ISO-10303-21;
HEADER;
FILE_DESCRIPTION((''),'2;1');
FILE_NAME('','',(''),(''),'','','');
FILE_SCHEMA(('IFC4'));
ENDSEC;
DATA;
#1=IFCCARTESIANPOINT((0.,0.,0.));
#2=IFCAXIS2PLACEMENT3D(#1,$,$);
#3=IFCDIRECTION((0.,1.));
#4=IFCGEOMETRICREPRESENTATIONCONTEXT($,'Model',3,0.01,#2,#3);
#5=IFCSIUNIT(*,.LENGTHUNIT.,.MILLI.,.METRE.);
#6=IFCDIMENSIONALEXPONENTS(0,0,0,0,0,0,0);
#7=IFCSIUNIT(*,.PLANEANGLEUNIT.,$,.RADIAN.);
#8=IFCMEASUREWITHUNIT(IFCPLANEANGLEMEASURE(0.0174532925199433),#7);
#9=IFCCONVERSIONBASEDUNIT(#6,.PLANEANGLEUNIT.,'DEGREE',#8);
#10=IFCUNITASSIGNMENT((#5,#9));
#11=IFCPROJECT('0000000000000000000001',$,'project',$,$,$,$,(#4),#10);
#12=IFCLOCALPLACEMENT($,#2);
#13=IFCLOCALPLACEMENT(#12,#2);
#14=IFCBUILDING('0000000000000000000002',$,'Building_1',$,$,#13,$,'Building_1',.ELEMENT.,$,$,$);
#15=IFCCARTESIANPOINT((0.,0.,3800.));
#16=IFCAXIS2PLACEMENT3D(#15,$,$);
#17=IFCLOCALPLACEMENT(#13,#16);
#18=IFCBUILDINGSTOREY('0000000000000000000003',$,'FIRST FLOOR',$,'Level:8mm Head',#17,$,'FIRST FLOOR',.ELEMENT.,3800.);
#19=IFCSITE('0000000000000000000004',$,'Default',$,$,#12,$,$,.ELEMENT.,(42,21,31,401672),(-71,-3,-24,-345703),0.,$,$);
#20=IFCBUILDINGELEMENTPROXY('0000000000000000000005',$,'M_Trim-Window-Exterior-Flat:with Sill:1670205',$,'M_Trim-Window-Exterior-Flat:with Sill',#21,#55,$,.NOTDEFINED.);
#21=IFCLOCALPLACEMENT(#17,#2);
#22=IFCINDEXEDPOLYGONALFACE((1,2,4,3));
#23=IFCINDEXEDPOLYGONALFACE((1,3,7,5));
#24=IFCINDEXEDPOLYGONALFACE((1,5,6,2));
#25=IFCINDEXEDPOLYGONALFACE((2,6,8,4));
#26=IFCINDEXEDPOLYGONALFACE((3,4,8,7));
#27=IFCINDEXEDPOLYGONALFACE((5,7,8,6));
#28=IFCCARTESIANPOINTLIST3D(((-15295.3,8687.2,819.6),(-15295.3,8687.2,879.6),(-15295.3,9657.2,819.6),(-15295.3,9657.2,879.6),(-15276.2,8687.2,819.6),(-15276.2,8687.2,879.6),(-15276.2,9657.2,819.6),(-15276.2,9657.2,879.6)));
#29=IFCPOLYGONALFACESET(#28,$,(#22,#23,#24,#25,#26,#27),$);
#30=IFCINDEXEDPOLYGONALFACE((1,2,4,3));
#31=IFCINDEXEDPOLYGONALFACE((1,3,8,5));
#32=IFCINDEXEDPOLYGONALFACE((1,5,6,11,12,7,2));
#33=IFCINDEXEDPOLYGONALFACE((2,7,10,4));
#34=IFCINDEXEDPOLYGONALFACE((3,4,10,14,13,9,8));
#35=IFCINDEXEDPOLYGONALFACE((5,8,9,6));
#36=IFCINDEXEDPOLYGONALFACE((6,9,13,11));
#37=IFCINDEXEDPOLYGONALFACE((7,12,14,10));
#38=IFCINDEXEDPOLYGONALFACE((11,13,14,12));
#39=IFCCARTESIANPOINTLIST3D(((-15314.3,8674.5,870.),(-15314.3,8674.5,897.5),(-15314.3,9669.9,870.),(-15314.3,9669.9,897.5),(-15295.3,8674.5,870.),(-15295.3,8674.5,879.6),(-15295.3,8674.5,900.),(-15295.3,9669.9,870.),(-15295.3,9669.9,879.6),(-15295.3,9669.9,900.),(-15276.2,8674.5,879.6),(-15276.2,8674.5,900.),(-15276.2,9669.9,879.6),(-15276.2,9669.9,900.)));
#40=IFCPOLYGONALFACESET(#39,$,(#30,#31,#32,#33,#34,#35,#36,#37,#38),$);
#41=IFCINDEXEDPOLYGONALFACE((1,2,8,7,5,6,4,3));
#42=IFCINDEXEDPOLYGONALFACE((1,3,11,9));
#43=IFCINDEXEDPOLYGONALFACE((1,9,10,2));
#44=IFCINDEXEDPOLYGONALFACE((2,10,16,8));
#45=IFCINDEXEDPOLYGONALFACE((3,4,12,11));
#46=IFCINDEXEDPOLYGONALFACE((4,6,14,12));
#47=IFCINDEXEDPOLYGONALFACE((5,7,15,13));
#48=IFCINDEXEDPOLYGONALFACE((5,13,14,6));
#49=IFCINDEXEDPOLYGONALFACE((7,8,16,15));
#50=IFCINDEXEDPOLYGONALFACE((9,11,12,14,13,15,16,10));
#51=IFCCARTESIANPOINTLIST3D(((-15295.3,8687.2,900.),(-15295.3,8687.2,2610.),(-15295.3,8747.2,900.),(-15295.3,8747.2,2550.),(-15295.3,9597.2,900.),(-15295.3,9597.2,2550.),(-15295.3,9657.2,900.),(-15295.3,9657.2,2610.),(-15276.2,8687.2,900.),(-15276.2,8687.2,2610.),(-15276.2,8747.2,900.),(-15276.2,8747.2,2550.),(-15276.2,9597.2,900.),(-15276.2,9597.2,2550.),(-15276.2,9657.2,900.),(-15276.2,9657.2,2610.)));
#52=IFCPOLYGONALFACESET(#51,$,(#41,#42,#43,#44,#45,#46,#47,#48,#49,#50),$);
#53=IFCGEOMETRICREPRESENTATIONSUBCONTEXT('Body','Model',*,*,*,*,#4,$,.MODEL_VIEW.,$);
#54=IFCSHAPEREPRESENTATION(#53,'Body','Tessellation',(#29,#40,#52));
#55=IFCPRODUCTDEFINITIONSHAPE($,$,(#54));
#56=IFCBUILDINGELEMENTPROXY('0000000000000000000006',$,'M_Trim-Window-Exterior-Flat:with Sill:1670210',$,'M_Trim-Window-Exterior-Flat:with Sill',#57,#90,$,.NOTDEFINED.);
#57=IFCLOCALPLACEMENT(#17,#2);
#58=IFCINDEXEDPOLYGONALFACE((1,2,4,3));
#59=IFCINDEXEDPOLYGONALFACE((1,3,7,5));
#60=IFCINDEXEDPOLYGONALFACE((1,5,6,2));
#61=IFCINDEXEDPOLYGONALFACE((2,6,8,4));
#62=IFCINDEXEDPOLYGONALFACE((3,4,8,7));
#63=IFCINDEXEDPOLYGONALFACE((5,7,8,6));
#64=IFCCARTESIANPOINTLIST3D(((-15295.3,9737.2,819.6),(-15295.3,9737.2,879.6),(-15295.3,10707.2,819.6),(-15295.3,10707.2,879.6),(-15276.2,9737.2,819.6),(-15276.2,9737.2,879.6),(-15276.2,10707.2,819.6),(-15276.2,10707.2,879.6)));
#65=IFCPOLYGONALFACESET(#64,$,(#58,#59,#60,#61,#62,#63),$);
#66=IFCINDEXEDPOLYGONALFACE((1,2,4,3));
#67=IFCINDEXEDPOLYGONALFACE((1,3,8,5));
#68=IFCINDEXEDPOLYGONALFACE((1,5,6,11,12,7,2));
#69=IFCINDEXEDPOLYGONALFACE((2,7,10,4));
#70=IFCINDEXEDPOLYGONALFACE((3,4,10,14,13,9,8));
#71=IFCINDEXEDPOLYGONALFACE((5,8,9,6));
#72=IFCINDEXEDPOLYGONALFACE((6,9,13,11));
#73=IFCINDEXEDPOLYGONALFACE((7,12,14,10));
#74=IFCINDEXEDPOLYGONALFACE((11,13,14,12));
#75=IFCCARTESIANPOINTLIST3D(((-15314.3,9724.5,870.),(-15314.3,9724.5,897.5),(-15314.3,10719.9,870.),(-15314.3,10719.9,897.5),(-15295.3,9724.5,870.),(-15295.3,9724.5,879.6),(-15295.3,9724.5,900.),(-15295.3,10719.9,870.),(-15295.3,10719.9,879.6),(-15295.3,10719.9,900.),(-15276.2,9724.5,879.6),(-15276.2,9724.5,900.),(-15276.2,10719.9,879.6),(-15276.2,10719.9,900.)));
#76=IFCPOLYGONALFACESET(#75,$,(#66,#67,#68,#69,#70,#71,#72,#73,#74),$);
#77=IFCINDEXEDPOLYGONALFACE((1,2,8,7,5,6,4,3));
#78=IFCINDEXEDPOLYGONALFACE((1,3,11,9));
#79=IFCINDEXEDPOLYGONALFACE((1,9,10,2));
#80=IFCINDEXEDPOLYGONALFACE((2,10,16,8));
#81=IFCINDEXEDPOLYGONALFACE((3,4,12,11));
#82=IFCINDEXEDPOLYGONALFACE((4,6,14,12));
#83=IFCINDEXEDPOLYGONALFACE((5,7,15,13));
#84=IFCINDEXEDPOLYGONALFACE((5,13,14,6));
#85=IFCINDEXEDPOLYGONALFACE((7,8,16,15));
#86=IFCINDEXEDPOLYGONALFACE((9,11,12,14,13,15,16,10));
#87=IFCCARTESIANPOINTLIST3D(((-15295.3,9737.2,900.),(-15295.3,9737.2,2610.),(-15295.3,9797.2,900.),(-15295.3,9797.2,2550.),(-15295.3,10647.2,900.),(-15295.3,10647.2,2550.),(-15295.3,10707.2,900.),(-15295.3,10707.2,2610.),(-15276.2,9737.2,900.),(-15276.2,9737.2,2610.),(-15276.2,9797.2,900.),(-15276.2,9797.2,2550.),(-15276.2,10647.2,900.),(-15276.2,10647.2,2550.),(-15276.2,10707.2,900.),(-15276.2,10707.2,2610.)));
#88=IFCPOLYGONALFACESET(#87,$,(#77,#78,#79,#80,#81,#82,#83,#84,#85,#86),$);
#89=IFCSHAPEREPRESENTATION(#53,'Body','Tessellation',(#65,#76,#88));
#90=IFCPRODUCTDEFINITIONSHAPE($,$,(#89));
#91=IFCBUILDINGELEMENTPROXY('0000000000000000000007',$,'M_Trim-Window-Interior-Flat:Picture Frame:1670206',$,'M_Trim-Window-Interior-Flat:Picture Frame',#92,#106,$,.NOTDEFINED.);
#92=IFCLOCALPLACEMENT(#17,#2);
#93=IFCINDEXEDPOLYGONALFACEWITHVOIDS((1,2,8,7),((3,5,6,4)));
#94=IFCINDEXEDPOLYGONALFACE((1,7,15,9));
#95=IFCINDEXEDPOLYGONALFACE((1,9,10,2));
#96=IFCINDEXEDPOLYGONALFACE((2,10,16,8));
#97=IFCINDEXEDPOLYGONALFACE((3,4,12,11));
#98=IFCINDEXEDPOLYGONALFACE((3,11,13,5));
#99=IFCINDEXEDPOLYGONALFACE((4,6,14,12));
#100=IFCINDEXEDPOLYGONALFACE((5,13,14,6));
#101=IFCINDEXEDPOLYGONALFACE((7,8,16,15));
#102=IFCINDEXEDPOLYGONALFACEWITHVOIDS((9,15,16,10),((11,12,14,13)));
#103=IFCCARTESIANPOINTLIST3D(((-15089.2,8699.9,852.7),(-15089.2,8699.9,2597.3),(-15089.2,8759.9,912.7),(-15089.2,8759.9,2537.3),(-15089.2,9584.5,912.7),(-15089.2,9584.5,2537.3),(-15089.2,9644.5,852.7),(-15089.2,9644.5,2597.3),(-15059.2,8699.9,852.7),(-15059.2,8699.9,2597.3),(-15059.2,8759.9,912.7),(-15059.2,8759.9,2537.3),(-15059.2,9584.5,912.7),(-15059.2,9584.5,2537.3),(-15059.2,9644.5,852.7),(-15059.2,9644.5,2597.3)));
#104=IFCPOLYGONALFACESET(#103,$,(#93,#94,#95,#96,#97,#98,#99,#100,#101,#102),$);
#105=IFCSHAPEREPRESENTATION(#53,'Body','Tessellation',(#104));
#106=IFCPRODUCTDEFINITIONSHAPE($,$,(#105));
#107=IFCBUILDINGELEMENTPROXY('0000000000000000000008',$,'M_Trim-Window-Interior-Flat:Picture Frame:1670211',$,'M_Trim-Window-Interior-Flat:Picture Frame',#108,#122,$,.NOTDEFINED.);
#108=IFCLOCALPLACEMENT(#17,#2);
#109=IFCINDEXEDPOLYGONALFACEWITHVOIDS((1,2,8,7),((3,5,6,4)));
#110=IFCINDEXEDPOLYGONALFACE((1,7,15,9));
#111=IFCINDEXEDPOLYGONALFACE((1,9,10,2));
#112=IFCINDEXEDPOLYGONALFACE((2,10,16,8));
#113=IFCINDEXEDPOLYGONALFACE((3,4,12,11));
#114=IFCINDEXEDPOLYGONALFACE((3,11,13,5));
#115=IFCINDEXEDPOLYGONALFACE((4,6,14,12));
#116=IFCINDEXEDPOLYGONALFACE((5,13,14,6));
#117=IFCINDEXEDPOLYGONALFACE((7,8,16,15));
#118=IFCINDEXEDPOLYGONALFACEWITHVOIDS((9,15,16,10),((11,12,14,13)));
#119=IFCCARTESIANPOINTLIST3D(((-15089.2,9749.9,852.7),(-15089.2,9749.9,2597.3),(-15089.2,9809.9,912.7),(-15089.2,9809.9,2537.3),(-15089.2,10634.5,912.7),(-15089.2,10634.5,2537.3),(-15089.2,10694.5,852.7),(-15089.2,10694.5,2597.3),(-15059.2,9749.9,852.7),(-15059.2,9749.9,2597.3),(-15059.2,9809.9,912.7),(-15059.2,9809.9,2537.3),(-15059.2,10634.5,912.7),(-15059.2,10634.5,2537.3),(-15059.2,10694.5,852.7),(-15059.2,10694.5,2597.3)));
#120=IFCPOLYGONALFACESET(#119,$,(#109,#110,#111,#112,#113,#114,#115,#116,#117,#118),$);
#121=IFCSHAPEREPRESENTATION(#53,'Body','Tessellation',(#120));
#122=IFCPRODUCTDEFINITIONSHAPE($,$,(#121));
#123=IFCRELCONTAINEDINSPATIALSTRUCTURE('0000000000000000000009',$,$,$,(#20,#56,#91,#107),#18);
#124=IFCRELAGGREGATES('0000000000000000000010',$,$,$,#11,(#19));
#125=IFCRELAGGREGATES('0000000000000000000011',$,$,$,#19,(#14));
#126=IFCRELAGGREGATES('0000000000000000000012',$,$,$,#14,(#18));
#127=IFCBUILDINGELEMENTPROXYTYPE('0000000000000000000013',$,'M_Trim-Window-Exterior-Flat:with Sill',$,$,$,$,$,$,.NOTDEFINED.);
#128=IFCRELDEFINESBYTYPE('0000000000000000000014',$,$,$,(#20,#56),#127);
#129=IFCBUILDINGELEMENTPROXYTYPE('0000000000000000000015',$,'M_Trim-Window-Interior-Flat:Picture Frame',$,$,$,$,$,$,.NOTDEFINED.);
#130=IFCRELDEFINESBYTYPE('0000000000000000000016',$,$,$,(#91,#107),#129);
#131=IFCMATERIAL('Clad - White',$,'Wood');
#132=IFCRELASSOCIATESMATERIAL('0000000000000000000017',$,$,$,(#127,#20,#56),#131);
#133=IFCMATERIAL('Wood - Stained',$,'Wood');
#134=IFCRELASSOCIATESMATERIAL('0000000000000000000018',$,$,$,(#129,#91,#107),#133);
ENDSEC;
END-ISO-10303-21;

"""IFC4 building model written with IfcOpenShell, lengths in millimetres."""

from ifc_helpers import new_model, entity, si_unit, converted_unit, direction, frame, origin, place, context, subcontext, project, spatial, indexed_curve, outline, extrude, source, transform, mapped, material, type_object, type_shapes, element, save


model = new_model("IFC4")

# Units and contexts
model_context = context("Model", 3, precision=0.01, world=origin(), true_north=direction((0.0, 1.0)))
body_context = subcontext(model_context, "Body", "Model", "MODEL_VIEW")
ifc_project = project(units=[si_unit("LENGTHUNIT", "METRE", prefix="MILLI"), converted_unit("PLANEANGLEUNIT", "DEGREE", entity("IfcPlaneAngleMeasure", 0.0174532925199433), si_unit("PLANEANGLEUNIT", "RADIAN"), dimensions=[0, 0, 0, 0, 0, 0, 0])], contexts=[model_context])

# Site, building, storey
site_placement = place(None, origin())
site = spatial("IfcSite", under=ifc_project, at=site_placement, Name="Default", CompositionType="ELEMENT", RefLatitude=(42, 21, 31, 401672), RefLongitude=(-71, -3, -24, -345703), RefElevation=0.0)
building_placement = place(site_placement, origin())
building = spatial("IfcBuilding", under=site, at=building_placement, Name="Building_1", LongName="Building_1", CompositionType="ELEMENT")
storey_placement = place(building_placement, frame((0.0, 0.0, 3800.0)))
storey = spatial("IfcBuildingStorey", under=building, at=storey_placement, Name="FIRST FLOOR", ObjectType="Level:8mm Head", LongName="FIRST FLOOR", CompositionType="ELEMENT", Elevation=3800.0)

# Shared definitions
ifc_material_1 = material(Name="Wood - Stained", Category="Wood")

# Building element proxies
ifc_material_2 = material(Name="Clad - White", Category="Wood")
building_element_proxy_type_1 = type_object("IfcBuildingElementProxyType", Name="M_Trim-Window-Exterior-Flat:with Sill", PredefinedType="NOTDEFINED", material=ifc_material_2)
shared_shape_1 = source(origin(), body_context, "Body", "SweptSolid", [
    extrude(outline(indexed_curve([(-485.0, -30.0), (485.0, -30.0), (485.0, 30.0), (-485.0, 30.0), (-485.0, -30.0)], self_intersect=False)), frame((0.0, -1700.4, 0.0), z_axis=(0.0, 0.0, 1.0), x_axis=(-1.0, 0.0, 0.0)), (0.0, 0.0, 1.0), 19.1),
    extrude(outline(indexed_curve([(-19.0, -15.2), (0.0, -15.2), (0.0, -5.7), (19.0, -5.7), (19.0, 14.8), (0.0, 14.8), (-19.0, 12.3), (-19.0, -15.2)], self_intersect=False)), frame((-497.7, -1664.8, 19.0), z_axis=(1.0, 0.0, 0.0), x_axis=(0.0, 0.0, -1.0)), (0.0, 0.0, 1.0), 995.4),
    extrude(outline(indexed_curve([(-870.0, -485.0), (840.0, -485.0), (840.0, -425.0), (-810.0, -425.0), (-810.0, 425.0), (840.0, 425.0), (840.0, 485.0), (-870.0, 485.0), (-870.0, -485.0)], self_intersect=False)), frame((0.0, -810.0, 0.0), z_axis=(0.0, 0.0, 1.0), x_axis=(0.0, -1.0, 0.0)), (0.0, 0.0, 1.0), 19.1),
])
type_shapes(building_element_proxy_type_1, [shared_shape_1])
for number, where, z_axis, x_axis, name in (
    (1, (-15276.2, 9172.2, 2550.0), (-1.0, 0.0, 0.0), (0.0, -1.0, 0.0), "M_Trim-Window-Exterior-Flat:with Sill:1670205"),
    (2, (-15276.2, 10222.2, 2550.0), (-1.0, 0.0, 0.0), (0.0, -1.0, 0.0), "M_Trim-Window-Exterior-Flat:with Sill:1670210"),
):
    element("IfcBuildingElementProxy", number, at=place(storey_placement, frame(where, z_axis=z_axis, x_axis=x_axis)), inside=storey, type_object=building_element_proxy_type_1, material=ifc_material_2, Name=name, ObjectType="M_Trim-Window-Exterior-Flat:with Sill", PredefinedType="NOTDEFINED", context=body_context, shape_type="MappedRepresentation", body=[
        mapped(shared_shape_1, transform((0.0, 0.0, 0.0), scale=1.0)),
    ])
building_element_proxy_type_2 = type_object("IfcBuildingElementProxyType", Name="M_Trim-Window-Interior-Flat:Picture Frame", PredefinedType="NOTDEFINED", material=ifc_material_1)
shared_shape_2 = source(origin(), body_context, "Body", "SweptSolid", [
    extrude(outline(indexed_curve([(-472.3, -872.3), (472.3, -872.3), (472.3, 872.3), (-472.3, 872.3), (-472.3, -872.3)], self_intersect=False), holes=[indexed_curve([(-412.3, -812.3), (-412.3, 812.3), (412.3, 812.3), (412.3, -812.3), (-412.3, -812.3)], self_intersect=False)]), frame((0.0, -825.0, 0.0), z_axis=(0.0, 0.0, 1.0), x_axis=(-1.0, 0.0, 0.0)), (0.0, 0.0, 1.0), 30.0),
])
type_shapes(building_element_proxy_type_2, [shared_shape_2])
for number, where, z_axis, x_axis, name in (
    (3, (-15089.2, 9172.2, 2550.0), (1.0, 0.0, 0.0), (0.0, 1.0, 0.0), "M_Trim-Window-Interior-Flat:Picture Frame:1670206"),
    (4, (-15089.2, 10222.2, 2550.0), (1.0, 0.0, 0.0), (0.0, 1.0, 0.0), "M_Trim-Window-Interior-Flat:Picture Frame:1670211"),
):
    element("IfcBuildingElementProxy", number, at=place(storey_placement, frame(where, z_axis=z_axis, x_axis=x_axis)), inside=storey, type_object=building_element_proxy_type_2, material=ifc_material_1, Name=name, ObjectType="M_Trim-Window-Interior-Flat:Picture Frame", PredefinedType="NOTDEFINED", context=body_context, shape_type="MappedRepresentation", body=[
        mapped(shared_shape_2, transform((0.0, 0.0, 0.0), scale=1.0)),
    ])

save(model, "model.ifc")
